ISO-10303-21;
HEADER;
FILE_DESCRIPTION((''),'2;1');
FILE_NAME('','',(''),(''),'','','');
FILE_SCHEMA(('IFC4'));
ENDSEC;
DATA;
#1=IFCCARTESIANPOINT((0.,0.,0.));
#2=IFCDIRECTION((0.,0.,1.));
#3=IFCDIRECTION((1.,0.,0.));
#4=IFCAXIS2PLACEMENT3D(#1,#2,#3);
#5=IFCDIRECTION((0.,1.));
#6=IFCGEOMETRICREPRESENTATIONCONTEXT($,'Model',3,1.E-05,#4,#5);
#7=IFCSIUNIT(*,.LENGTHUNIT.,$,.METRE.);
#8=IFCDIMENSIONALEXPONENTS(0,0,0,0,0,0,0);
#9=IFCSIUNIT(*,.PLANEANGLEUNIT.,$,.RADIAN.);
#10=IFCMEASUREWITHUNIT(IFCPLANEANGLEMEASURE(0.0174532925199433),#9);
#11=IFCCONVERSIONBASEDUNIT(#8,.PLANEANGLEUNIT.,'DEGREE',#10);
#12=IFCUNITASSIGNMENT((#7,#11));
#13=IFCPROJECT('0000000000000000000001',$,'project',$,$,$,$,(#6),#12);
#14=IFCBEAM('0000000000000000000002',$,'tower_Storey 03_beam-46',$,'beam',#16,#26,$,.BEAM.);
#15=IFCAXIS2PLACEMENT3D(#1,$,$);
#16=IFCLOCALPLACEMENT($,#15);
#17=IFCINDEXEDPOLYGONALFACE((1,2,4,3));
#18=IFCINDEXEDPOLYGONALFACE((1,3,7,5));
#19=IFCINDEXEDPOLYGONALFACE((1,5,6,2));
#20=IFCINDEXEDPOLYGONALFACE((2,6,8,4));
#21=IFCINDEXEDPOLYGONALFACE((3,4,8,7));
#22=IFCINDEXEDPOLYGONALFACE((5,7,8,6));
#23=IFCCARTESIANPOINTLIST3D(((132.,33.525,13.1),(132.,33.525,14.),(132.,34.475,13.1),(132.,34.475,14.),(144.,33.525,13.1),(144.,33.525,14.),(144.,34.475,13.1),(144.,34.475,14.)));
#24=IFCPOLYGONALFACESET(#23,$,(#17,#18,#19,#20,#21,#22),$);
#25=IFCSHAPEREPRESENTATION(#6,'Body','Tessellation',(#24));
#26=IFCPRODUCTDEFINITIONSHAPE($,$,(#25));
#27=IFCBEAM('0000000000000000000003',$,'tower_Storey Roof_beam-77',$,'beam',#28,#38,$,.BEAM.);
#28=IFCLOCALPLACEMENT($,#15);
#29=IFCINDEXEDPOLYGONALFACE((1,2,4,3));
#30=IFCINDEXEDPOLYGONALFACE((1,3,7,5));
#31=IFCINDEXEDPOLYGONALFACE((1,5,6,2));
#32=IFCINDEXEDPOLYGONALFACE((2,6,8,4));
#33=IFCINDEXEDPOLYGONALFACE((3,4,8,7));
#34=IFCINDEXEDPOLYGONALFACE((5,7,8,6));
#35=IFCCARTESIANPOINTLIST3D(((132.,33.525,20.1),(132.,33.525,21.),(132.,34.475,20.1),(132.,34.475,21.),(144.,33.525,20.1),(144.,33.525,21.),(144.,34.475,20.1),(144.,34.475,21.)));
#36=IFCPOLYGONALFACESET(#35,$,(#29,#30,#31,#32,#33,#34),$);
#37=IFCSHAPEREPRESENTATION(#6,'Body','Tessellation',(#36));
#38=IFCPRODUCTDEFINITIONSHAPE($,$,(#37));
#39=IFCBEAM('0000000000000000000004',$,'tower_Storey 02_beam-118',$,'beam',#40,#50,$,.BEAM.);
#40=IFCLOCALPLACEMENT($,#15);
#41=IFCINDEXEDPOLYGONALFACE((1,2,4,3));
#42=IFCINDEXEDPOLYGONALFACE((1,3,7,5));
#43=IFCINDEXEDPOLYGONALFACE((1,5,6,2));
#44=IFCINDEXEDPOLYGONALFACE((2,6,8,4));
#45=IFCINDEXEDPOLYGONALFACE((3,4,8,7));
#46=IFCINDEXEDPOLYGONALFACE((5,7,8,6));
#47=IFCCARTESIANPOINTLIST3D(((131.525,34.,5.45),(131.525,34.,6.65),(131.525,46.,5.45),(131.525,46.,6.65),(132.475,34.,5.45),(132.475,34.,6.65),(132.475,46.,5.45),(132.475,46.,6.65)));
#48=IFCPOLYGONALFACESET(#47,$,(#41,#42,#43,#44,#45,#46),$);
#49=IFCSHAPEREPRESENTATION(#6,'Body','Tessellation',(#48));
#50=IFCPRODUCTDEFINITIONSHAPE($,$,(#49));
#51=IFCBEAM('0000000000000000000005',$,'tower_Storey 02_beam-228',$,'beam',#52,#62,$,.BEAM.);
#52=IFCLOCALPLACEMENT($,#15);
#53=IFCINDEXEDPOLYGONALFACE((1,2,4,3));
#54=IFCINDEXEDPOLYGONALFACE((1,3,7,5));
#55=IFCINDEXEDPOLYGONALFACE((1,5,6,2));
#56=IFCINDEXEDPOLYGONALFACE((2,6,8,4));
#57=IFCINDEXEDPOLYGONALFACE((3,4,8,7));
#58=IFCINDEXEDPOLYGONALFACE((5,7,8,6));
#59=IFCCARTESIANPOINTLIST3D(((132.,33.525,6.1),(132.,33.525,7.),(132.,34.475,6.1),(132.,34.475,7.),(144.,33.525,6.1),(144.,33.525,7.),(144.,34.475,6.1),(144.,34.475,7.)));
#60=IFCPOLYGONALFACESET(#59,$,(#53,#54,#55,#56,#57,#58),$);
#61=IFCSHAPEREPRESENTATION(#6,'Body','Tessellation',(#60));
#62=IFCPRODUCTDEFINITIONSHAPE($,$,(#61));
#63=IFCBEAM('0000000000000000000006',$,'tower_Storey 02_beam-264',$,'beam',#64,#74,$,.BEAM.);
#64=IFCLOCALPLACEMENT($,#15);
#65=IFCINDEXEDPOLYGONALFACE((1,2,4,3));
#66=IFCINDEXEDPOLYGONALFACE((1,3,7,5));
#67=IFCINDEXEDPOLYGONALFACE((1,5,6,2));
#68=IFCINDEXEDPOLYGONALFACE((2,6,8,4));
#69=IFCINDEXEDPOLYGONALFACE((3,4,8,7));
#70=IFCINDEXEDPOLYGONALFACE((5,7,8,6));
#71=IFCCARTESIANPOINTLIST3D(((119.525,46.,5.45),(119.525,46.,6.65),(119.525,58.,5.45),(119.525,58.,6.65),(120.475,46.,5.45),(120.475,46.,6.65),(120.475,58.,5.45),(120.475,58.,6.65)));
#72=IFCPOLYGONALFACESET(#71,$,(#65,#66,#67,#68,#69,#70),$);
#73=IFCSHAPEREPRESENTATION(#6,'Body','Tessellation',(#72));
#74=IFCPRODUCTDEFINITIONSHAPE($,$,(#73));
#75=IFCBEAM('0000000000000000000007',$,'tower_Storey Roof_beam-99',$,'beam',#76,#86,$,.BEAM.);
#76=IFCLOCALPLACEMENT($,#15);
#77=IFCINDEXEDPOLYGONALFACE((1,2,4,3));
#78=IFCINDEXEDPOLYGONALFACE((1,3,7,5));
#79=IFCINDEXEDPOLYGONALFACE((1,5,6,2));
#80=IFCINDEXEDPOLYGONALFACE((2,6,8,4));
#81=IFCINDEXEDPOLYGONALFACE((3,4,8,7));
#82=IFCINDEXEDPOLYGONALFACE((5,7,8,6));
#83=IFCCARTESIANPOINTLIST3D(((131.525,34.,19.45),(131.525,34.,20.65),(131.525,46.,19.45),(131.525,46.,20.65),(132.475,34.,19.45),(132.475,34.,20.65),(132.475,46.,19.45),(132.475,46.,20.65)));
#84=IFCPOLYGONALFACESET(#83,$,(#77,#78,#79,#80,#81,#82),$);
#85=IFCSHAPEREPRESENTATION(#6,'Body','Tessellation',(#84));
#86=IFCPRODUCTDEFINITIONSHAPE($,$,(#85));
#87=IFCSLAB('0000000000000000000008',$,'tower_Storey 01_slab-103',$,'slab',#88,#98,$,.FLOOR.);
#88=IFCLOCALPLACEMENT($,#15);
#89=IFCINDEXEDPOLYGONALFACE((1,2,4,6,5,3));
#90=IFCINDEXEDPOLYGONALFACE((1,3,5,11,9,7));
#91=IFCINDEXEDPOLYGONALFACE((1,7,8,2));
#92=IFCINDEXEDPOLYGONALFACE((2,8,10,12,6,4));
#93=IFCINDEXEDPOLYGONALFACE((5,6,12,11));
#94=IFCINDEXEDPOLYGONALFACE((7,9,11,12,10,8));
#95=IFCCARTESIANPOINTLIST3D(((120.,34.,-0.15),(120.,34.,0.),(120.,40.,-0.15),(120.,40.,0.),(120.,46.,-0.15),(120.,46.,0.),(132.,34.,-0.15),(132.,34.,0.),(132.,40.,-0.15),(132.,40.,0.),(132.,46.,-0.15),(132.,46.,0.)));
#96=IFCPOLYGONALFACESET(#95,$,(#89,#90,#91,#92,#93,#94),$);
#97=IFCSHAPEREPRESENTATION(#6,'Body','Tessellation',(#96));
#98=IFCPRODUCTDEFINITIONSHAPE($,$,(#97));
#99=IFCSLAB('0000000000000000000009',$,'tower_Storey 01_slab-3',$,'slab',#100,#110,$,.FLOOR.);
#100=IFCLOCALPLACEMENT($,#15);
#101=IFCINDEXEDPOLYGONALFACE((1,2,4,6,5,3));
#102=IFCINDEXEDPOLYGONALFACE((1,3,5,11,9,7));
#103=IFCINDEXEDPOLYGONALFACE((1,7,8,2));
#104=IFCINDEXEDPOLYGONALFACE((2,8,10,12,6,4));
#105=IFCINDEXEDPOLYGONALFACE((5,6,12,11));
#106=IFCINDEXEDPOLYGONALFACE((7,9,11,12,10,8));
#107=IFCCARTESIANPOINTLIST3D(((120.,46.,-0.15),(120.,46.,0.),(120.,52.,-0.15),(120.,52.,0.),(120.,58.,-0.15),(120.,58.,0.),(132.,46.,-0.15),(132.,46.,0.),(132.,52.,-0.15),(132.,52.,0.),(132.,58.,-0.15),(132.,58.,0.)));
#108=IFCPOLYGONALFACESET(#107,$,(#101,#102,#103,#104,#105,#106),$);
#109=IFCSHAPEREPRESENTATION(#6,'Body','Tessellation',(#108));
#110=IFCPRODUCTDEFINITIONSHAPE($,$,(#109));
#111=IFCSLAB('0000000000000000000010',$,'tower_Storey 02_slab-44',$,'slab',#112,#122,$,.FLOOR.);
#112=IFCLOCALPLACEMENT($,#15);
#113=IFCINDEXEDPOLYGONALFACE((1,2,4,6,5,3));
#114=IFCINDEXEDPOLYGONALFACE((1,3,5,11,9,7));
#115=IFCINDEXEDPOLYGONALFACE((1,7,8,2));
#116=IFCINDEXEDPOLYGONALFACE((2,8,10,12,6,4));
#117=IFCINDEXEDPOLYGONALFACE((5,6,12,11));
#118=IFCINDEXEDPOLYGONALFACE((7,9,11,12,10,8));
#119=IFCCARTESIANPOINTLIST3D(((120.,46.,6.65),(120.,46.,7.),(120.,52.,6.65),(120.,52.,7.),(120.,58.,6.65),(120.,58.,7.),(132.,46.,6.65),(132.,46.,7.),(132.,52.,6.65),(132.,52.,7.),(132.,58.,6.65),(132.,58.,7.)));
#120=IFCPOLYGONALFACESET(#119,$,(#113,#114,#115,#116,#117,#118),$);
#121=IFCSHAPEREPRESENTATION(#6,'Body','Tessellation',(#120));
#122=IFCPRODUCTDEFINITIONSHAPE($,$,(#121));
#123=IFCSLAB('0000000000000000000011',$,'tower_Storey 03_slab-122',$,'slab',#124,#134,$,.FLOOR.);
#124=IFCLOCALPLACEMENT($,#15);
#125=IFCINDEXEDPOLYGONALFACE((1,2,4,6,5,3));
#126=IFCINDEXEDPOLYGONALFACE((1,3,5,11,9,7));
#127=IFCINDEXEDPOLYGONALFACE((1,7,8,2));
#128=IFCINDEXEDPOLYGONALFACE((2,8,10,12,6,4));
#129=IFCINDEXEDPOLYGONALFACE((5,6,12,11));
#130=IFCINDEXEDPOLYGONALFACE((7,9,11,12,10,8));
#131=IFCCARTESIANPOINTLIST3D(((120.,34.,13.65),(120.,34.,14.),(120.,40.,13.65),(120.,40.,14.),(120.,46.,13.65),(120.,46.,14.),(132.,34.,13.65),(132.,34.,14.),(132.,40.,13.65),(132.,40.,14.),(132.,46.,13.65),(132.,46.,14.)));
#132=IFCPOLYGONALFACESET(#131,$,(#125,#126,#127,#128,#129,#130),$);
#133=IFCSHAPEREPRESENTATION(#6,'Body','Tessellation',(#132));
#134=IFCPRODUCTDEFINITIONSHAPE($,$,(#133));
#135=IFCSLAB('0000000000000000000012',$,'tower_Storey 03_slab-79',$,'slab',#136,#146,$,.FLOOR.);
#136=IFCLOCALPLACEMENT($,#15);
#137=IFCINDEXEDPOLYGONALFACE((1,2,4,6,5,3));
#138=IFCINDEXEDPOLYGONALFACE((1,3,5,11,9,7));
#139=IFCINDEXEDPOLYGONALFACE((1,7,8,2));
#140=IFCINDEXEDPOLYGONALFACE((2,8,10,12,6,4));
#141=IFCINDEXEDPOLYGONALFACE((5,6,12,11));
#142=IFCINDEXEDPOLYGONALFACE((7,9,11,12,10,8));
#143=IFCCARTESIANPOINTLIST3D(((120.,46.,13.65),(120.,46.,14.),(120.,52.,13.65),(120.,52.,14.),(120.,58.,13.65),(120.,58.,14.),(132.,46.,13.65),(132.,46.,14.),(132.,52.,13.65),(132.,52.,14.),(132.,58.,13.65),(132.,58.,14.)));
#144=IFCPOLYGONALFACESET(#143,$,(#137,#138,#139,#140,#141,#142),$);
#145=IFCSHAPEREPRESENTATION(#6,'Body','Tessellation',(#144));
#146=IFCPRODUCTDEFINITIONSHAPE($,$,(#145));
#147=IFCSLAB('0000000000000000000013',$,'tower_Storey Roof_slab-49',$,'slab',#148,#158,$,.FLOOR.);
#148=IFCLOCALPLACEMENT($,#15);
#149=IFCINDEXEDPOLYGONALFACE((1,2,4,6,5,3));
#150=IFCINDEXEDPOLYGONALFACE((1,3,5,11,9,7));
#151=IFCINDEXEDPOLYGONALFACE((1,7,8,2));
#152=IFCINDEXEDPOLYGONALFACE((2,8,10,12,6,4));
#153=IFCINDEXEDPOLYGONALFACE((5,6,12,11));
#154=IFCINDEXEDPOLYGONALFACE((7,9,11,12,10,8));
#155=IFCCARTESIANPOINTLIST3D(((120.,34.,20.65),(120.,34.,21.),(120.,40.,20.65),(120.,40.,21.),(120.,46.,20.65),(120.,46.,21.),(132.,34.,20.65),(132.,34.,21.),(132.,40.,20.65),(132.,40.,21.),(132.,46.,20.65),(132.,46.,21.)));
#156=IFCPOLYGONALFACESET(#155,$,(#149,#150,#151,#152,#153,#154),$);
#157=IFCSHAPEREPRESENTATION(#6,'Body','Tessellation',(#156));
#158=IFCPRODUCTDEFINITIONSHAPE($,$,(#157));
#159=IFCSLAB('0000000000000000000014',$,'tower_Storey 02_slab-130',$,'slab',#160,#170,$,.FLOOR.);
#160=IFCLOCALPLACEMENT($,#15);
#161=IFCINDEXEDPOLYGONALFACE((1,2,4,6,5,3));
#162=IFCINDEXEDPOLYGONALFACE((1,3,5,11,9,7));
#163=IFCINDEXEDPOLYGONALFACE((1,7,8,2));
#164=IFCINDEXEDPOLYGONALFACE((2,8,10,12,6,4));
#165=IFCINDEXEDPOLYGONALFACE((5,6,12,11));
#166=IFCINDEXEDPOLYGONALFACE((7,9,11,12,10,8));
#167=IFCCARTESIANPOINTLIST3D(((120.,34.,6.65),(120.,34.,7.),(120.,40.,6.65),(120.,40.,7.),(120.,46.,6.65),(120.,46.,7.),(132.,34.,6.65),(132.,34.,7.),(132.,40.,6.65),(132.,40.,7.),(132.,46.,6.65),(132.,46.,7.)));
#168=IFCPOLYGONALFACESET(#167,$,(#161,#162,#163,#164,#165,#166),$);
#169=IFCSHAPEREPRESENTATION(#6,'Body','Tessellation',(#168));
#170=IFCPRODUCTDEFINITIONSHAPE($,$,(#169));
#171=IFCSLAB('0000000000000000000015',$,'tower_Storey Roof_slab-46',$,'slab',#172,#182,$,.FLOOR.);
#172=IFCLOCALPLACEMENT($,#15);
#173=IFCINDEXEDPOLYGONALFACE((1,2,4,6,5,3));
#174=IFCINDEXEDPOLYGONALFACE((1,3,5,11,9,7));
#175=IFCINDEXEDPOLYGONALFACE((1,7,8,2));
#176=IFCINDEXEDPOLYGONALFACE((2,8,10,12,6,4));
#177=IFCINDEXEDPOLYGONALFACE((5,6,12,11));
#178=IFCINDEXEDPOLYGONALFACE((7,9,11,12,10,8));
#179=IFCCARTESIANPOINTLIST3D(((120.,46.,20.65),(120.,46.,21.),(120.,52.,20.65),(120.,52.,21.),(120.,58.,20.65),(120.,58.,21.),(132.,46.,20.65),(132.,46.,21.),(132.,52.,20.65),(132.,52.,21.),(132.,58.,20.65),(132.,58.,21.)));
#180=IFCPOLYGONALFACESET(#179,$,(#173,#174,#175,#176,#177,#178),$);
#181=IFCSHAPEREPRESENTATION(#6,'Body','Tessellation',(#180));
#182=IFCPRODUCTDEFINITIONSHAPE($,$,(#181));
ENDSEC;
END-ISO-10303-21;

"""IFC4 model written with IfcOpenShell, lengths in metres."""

from ifc_helpers import new_model, entity, si_unit, converted_unit, direction, frame, origin_with_axes, place, context, project, polyline, outline, extrude, element, save


model = new_model("IFC4")

# Units and contexts
model_context = context("Model", 3, precision=1e-05, world=origin_with_axes(), true_north=direction((0.0, 1.0)))
ifc_project = project(units=[si_unit("LENGTHUNIT", "METRE"), converted_unit("PLANEANGLEUNIT", "DEGREE", entity("IfcPlaneAngleMeasure", 0.0174532925199433), si_unit("PLANEANGLEUNIT", "RADIAN"), dimensions=[0, 0, 0, 0, 0, 0, 0])], contexts=[model_context])

# Shared definitions
placement_1 = place(None, origin_with_axes())
placement_2 = place(placement_1, origin_with_axes())

# Shared definitions
placement_3 = place(placement_1, frame((0.0, 0.0, 7.0), z_axis=(0.0, 0.0, 1.0), x_axis=(1.0, 0.0, 0.0)))
placement_4 = place(placement_1, frame((0.0, 0.0, 14.0), z_axis=(0.0, 0.0, 1.0), x_axis=(1.0, 0.0, 0.0)))

# Beams
placement_5 = place(placement_1, frame((0.0, 0.0, 21.0), z_axis=(0.0, 0.0, 1.0), x_axis=(1.0, 0.0, 0.0)))
beam_1_placement = place(placement_4, frame((132.0, 34.0, -0.45), z_axis=(1.0, 0.0, 0.0), x_axis=(0.0, 1.0, 0.0)))
element("IfcBeam", 1, at=beam_1_placement, Name="tower_Storey 03_beam-46", ObjectType="beam", PredefinedType="BEAM", context=model_context, body=[
    extrude(outline(polyline([(0.475, 0.45, 0.0), (-0.475, 0.45, 0.0), (-0.475, -0.45, 0.0), (0.475, -0.45, 0.0), (0.475, 0.45, 0.0)])), origin_with_axes(), (0.0, 0.0, 1.0), 12.0),
])
beam_2_placement = place(placement_5, frame((132.0, 34.0, -0.45), z_axis=(1.0, 0.0, 0.0), x_axis=(0.0, 1.0, 0.0)))
element("IfcBeam", 2, at=beam_2_placement, Name="tower_Storey Roof_beam-77", ObjectType="beam", PredefinedType="BEAM", context=model_context, body=[
    extrude(outline(polyline([(0.475, 0.45, 0.0), (-0.475, 0.45, 0.0), (-0.475, -0.45, 0.0), (0.475, -0.45, 0.0), (0.475, 0.45, 0.0)])), origin_with_axes(), (0.0, 0.0, 1.0), 12.0),
])
beam_3_placement = place(placement_3, frame((132.0, 34.0, -0.95), z_axis=(0.0, 1.0, 0.0), x_axis=(-1.0, 0.0, 0.0)))
element("IfcBeam", 3, at=beam_3_placement, Name="tower_Storey 02_beam-118", ObjectType="beam", PredefinedType="BEAM", context=model_context, body=[
    extrude(outline(polyline([(0.475, 0.6, 0.0), (-0.475, 0.6, 0.0), (-0.475, -0.6, 0.0), (0.475, -0.6, 0.0), (0.475, 0.6, 0.0)])), origin_with_axes(), (0.0, 0.0, 1.0), 12.0),
])
beam_4_placement = place(placement_3, frame((132.0, 34.0, -0.45), z_axis=(1.0, 0.0, 0.0), x_axis=(0.0, 1.0, 0.0)))
element("IfcBeam", 4, at=beam_4_placement, Name="tower_Storey 02_beam-228", ObjectType="beam", PredefinedType="BEAM", context=model_context, body=[
    extrude(outline(polyline([(0.475, 0.45, 0.0), (-0.475, 0.45, 0.0), (-0.475, -0.45, 0.0), (0.475, -0.45, 0.0), (0.475, 0.45, 0.0)])), origin_with_axes(), (0.0, 0.0, 1.0), 12.0),
])
beam_5_placement = place(placement_3, frame((120.0, 46.0, -0.95), z_axis=(0.0, 1.0, 0.0), x_axis=(-1.0, 0.0, 0.0)))
element("IfcBeam", 5, at=beam_5_placement, Name="tower_Storey 02_beam-264", ObjectType="beam", PredefinedType="BEAM", context=model_context, body=[
    extrude(outline(polyline([(0.475, 0.6, 0.0), (-0.475, 0.6, 0.0), (-0.475, -0.6, 0.0), (0.475, -0.6, 0.0), (0.475, 0.6, 0.0)])), origin_with_axes(), (0.0, 0.0, 1.0), 12.0),
])
beam_6_placement = place(placement_5, frame((132.0, 34.0, -0.95), z_axis=(0.0, 1.0, 0.0), x_axis=(-1.0, 0.0, 0.0)))
element("IfcBeam", 6, at=beam_6_placement, Name="tower_Storey Roof_beam-99", ObjectType="beam", PredefinedType="BEAM", context=model_context, body=[
    extrude(outline(polyline([(0.475, 0.6, 0.0), (-0.475, 0.6, 0.0), (-0.475, -0.6, 0.0), (0.475, -0.6, 0.0), (0.475, 0.6, 0.0)])), origin_with_axes(), (0.0, 0.0, 1.0), 12.0),
])

# Slabs
for number, where, z_axis, x_axis, name in (
    (7, (126.0, 40.0, -0.15), (0.0, 0.0, 1.0), (1.0, 0.0, 0.0), "tower_Storey 01_slab-103"),
    (8, (126.0, 52.0, -0.15), (0.0, 0.0, 1.0), (1.0, 0.0, 0.0), "tower_Storey 01_slab-3"),
):
    element("IfcSlab", number, at=place(placement_2, frame(where, z_axis=z_axis, x_axis=x_axis)), Name=name, ObjectType="slab", PredefinedType="FLOOR", context=model_context, body=[
        extrude(outline(polyline([(-6.0, -6.0, 0.0), (6.0, -6.0, 0.0), (6.0, 0.0, 0.0), (6.0, 6.0, 0.0), (-6.0, 6.0, 0.0), (-6.0, 0.0, 0.0), (-6.0, -6.0, 0.0)])), origin_with_axes(), (0.0, 0.0, 1.0), 0.15),
    ])
slab_1_placement = place(placement_3, frame((126.0, 52.0, -0.35), z_axis=(0.0, 0.0, 1.0), x_axis=(1.0, 0.0, 0.0)))
element("IfcSlab", 9, at=slab_1_placement, Name="tower_Storey 02_slab-44", ObjectType="slab", PredefinedType="FLOOR", context=model_context, body=[
    extrude(outline(polyline([(-6.0, -6.0, 0.0), (6.0, -6.0, 0.0), (6.0, 0.0, 0.0), (6.0, 6.0, 0.0), (-6.0, 6.0, 0.0), (-6.0, 0.0, 0.0), (-6.0, -6.0, 0.0)])), origin_with_axes(), (0.0, 0.0, 1.0), 0.35),
])
for number, where, z_axis, x_axis, name in (
    (10, (126.0, 40.0, -0.35), (0.0, 0.0, 1.0), (1.0, 0.0, 0.0), "tower_Storey 03_slab-122"),
    (11, (126.0, 52.0, -0.35), (0.0, 0.0, 1.0), (1.0, 0.0, 0.0), "tower_Storey 03_slab-79"),
):
    element("IfcSlab", number, at=place(placement_4, frame(where, z_axis=z_axis, x_axis=x_axis)), Name=name, ObjectType="slab", PredefinedType="FLOOR", context=model_context, body=[
        extrude(outline(polyline([(-6.0, -6.0, 0.0), (6.0, -6.0, 0.0), (6.0, 0.0, 0.0), (6.0, 6.0, 0.0), (-6.0, 6.0, 0.0), (-6.0, 0.0, 0.0), (-6.0, -6.0, 0.0)])), origin_with_axes(), (0.0, 0.0, 1.0), 0.35),
    ])
slab_2_placement = place(placement_5, frame((126.0, 40.0, -0.35), z_axis=(0.0, 0.0, 1.0), x_axis=(1.0, 0.0, 0.0)))
element("IfcSlab", 12, at=slab_2_placement, Name="tower_Storey Roof_slab-49", ObjectType="slab", PredefinedType="FLOOR", context=model_context, body=[
    extrude(outline(polyline([(-6.0, -6.0, 0.0), (6.0, -6.0, 0.0), (6.0, 0.0, 0.0), (6.0, 6.0, 0.0), (-6.0, 6.0, 0.0), (-6.0, 0.0, 0.0), (-6.0, -6.0, 0.0)])), origin_with_axes(), (0.0, 0.0, 1.0), 0.35),
])
slab_3_placement = place(placement_3, frame((126.0, 40.0, -0.35), z_axis=(0.0, 0.0, 1.0), x_axis=(1.0, 0.0, 0.0)))
element("IfcSlab", 13, at=slab_3_placement, Name="tower_Storey 02_slab-130", ObjectType="slab", PredefinedType="FLOOR", context=model_context, body=[
    extrude(outline(polyline([(-6.0, -6.0, 0.0), (6.0, -6.0, 0.0), (6.0, 0.0, 0.0), (6.0, 6.0, 0.0), (-6.0, 6.0, 0.0), (-6.0, 0.0, 0.0), (-6.0, -6.0, 0.0)])), origin_with_axes(), (0.0, 0.0, 1.0), 0.35),
])
slab_4_placement = place(placement_5, frame((126.0, 52.0, -0.35), z_axis=(0.0, 0.0, 1.0), x_axis=(1.0, 0.0, 0.0)))
element("IfcSlab", 14, at=slab_4_placement, Name="tower_Storey Roof_slab-46", ObjectType="slab", PredefinedType="FLOOR", context=model_context, body=[
    extrude(outline(polyline([(-6.0, -6.0, 0.0), (6.0, -6.0, 0.0), (6.0, 0.0, 0.0), (6.0, 6.0, 0.0), (-6.0, 6.0, 0.0), (-6.0, 0.0, 0.0), (-6.0, -6.0, 0.0)])), origin_with_axes(), (0.0, 0.0, 1.0), 0.35),
])

save(model, "model.ifc")
